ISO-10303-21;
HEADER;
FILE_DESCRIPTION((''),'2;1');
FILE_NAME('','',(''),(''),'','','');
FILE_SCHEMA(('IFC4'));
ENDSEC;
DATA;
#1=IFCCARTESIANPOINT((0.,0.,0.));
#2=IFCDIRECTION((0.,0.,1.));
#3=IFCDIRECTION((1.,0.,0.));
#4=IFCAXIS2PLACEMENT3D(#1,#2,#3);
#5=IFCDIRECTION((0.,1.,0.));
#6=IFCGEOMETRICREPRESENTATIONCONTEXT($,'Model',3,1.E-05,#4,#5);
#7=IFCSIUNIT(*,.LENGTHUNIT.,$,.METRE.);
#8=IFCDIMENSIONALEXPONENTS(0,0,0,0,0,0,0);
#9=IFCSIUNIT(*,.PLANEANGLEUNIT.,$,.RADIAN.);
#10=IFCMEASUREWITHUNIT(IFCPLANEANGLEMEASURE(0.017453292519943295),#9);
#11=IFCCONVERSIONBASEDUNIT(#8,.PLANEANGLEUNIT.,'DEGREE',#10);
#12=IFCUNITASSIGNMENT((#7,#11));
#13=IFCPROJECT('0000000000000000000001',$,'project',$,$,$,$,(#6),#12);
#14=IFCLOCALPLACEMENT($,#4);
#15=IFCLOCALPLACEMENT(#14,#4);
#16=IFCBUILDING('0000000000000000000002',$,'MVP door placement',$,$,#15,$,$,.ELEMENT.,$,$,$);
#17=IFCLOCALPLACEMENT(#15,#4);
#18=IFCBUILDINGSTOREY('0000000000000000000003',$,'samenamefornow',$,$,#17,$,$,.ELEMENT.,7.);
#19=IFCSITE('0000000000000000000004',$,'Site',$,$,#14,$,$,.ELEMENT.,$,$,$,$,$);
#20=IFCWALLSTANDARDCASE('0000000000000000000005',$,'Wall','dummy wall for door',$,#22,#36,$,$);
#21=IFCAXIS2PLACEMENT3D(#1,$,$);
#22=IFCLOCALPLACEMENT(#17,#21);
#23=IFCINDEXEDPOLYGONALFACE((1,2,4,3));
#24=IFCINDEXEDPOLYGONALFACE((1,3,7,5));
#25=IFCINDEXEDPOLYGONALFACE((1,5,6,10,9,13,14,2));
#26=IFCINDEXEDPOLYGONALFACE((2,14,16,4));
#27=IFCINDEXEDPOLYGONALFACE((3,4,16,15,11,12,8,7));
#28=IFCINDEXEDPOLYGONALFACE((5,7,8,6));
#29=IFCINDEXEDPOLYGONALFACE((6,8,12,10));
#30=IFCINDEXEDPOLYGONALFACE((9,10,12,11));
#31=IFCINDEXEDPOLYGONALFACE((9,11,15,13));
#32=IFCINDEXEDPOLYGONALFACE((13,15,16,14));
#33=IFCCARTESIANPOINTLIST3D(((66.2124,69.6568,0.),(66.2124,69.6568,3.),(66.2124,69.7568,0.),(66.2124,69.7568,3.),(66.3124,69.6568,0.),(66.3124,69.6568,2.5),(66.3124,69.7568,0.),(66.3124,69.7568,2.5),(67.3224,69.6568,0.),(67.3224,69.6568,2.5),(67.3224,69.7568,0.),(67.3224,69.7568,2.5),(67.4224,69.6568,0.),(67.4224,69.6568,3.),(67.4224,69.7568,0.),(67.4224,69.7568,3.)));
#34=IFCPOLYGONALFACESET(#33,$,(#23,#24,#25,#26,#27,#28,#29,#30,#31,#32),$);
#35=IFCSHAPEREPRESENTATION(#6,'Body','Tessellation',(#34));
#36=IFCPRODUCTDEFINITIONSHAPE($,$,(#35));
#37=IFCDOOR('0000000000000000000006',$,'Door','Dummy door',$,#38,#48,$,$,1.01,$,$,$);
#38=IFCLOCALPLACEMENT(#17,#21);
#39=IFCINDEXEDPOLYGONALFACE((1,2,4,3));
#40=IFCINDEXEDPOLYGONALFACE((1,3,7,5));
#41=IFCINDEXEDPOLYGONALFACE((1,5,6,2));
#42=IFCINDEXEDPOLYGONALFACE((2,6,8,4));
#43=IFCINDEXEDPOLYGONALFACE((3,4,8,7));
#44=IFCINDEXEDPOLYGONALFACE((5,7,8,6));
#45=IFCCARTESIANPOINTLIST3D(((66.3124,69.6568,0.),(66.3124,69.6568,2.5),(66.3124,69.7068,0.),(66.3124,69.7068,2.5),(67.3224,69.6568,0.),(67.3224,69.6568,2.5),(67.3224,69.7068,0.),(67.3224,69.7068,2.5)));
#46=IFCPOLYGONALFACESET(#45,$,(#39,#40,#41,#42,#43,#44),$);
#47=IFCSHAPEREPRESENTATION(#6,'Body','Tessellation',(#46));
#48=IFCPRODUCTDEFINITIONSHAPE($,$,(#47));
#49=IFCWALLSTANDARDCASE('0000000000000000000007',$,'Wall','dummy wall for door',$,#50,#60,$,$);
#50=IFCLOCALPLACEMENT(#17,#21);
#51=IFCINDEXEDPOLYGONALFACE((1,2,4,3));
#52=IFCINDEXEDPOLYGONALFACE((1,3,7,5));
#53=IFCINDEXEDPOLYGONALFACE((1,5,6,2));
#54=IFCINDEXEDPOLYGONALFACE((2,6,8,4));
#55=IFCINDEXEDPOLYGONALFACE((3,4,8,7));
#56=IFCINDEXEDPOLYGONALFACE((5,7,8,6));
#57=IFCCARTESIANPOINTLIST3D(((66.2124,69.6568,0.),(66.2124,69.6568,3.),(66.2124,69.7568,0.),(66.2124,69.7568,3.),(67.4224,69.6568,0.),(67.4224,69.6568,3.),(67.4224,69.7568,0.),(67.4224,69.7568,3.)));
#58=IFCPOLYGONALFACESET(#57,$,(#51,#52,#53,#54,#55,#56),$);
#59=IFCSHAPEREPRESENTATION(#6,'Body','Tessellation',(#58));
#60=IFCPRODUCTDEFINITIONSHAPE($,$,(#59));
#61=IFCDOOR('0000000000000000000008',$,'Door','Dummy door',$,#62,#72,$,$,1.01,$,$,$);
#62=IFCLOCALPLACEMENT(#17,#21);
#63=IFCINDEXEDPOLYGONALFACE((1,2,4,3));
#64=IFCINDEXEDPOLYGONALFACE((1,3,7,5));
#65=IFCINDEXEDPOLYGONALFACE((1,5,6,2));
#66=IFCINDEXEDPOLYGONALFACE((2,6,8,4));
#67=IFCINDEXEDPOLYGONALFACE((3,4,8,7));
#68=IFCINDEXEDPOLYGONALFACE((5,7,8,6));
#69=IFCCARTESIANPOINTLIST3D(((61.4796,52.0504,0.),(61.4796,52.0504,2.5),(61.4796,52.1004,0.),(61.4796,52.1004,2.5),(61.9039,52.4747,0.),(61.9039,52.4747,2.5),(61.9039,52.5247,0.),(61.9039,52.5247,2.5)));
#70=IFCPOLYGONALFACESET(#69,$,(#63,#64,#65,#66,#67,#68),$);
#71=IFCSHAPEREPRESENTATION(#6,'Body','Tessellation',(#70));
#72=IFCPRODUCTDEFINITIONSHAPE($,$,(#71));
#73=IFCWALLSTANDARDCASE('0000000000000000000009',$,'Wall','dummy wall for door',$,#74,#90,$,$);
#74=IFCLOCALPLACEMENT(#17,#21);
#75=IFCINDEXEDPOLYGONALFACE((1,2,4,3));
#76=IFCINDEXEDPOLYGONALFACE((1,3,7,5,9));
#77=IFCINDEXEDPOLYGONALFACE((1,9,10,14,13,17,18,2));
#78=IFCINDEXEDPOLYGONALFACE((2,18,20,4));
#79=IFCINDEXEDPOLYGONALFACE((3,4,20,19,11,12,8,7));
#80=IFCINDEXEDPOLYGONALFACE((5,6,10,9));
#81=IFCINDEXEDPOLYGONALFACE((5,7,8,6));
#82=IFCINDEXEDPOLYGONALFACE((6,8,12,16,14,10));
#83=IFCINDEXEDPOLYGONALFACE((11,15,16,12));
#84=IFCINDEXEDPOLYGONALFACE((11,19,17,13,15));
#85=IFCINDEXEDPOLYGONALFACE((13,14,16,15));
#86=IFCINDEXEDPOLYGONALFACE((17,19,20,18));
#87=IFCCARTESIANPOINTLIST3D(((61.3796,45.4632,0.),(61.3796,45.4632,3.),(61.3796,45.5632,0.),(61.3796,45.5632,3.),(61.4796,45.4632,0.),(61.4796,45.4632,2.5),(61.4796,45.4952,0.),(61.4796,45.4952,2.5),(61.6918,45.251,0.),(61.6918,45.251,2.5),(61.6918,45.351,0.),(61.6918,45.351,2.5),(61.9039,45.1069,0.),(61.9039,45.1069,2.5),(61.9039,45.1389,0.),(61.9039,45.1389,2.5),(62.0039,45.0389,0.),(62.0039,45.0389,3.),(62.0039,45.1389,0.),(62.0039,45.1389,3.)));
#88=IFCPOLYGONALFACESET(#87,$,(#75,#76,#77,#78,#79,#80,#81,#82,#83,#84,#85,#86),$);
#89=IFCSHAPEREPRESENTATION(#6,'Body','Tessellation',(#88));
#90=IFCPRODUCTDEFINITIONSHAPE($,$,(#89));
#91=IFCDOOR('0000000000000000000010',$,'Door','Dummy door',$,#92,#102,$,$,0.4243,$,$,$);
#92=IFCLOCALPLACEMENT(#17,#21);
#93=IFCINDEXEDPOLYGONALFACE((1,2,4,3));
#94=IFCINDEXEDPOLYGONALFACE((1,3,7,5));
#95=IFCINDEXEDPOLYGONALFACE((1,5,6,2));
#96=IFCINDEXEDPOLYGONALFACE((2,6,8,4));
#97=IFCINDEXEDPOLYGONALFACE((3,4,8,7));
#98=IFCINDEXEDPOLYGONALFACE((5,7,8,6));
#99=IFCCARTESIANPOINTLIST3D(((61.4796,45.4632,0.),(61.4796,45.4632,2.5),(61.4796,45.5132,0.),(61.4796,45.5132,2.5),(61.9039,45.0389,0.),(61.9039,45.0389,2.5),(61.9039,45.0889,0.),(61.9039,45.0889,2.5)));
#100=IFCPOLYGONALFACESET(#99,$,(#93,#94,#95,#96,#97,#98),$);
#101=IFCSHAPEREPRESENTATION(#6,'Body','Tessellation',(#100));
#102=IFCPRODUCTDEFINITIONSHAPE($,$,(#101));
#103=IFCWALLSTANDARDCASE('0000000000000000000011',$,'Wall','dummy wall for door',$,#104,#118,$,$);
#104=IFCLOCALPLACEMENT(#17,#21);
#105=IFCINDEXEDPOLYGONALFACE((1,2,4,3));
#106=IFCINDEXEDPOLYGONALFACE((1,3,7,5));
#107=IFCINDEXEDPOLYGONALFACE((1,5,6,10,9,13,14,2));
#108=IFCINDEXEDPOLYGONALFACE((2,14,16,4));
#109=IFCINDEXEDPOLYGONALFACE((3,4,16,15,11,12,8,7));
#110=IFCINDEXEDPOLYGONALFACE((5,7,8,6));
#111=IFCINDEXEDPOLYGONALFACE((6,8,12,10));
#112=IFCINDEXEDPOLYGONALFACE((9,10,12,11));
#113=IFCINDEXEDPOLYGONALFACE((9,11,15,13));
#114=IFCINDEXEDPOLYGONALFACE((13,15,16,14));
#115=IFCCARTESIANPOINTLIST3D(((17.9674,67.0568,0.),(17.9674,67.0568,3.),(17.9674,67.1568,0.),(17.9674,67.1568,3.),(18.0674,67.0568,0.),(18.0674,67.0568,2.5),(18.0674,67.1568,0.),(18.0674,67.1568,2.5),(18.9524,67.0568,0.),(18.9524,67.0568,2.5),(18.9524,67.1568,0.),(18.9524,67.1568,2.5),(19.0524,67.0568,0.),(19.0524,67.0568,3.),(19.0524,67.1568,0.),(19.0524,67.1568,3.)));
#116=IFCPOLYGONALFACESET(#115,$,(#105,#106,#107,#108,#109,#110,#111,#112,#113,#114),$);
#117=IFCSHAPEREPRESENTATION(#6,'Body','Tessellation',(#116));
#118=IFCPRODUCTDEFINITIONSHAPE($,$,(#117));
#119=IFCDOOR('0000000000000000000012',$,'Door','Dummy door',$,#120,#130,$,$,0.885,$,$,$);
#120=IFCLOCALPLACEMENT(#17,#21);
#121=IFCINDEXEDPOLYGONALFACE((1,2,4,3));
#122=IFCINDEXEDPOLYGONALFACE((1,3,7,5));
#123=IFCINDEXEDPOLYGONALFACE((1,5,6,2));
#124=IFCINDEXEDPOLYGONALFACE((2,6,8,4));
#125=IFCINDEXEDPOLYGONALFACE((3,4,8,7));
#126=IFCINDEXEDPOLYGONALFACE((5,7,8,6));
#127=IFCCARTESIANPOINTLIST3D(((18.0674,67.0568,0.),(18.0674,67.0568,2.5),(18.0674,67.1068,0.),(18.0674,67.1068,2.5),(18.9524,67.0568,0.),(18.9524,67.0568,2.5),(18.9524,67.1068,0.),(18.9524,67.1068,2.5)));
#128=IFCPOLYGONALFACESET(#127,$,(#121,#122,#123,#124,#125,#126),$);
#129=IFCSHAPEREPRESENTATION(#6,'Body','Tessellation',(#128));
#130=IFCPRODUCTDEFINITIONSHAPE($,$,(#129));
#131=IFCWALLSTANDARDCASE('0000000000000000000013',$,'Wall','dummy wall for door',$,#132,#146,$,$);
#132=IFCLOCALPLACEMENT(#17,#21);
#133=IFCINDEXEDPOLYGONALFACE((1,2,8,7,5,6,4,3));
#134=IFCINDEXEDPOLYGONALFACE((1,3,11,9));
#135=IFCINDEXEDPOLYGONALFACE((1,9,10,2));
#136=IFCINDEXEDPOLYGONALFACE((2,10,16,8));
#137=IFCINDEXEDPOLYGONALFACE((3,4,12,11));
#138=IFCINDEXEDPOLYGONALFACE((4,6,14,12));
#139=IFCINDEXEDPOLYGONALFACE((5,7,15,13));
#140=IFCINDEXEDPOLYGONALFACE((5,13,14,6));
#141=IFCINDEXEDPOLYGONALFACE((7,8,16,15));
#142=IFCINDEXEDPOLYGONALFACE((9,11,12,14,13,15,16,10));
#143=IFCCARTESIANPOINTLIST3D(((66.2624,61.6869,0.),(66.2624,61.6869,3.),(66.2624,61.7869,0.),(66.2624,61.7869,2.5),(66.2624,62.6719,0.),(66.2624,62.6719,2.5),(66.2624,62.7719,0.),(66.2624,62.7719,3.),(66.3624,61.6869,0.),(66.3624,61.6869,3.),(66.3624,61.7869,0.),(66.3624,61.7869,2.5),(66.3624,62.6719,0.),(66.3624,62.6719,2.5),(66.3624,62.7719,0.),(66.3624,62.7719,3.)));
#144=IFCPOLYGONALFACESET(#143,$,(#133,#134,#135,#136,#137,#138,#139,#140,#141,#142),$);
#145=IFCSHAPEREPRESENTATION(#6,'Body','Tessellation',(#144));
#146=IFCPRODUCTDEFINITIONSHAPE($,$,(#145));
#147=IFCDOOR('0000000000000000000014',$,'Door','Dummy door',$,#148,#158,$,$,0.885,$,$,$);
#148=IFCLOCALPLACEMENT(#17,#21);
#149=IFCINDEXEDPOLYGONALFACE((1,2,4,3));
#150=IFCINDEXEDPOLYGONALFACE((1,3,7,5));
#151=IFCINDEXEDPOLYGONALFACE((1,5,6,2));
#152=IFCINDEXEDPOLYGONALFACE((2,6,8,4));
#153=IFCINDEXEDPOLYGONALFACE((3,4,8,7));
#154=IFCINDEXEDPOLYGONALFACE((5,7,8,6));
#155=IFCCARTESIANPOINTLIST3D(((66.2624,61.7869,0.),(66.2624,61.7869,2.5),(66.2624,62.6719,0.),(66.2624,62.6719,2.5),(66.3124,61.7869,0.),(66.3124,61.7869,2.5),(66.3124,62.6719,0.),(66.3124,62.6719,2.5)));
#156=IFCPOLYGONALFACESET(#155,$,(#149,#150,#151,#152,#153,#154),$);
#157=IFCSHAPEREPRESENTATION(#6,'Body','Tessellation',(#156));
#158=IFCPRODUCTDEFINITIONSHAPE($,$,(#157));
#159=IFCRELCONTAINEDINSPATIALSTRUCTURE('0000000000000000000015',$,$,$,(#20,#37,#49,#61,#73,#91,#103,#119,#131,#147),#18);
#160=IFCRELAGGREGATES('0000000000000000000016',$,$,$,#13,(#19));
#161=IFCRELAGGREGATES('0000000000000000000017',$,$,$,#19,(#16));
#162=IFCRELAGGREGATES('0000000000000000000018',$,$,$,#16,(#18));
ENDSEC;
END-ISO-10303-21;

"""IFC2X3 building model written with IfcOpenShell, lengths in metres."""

from ifc_helpers import new_model, entity, si_unit, converted_unit, direction, origin_with_axes, place, context, project, spatial, polyline, outline, extrude, element, fill, save


model = new_model("IFC2X3")

# Units and contexts
model_context = context("Model", 3, precision=1e-05, world=origin_with_axes(), true_north=direction((0.0, 1.0, 0.0)))
ifc_project = project(units=[si_unit("LENGTHUNIT", "METRE"), converted_unit("PLANEANGLEUNIT", "DEGREE", entity("IfcPlaneAngleMeasure", 0.017453292519943295), si_unit("PLANEANGLEUNIT", "RADIAN"), dimensions=[0, 0, 0, 0, 0, 0, 0])], contexts=[model_context])

# Site, building, storey
site_placement = place(None, origin_with_axes())
site = spatial("IfcSite", under=ifc_project, at=site_placement, Name="Site", CompositionType="ELEMENT")
building_placement = place(site_placement, origin_with_axes())
building = spatial("IfcBuilding", under=site, at=building_placement, Name="MVP door placement", CompositionType="ELEMENT")
storey_placement = place(building_placement, origin_with_axes())
storey = spatial("IfcBuildingStorey", under=building, at=storey_placement, Name="samenamefornow", CompositionType="ELEMENT", Elevation=7.0)

# Walls, openings, doors
wall_1_placement = place(storey_placement, origin_with_axes())
wall_1 = element("IfcWallStandardCase", 1, at=wall_1_placement, inside=storey, Name="Wall", Description="dummy wall for door", context=model_context, shape_type="SweptSolid", body=[
    extrude(outline(polyline([(66.2124, 69.6568, 0.0), (67.4224, 69.6568, 0.0), (67.4224, 69.7568, 0.0), (66.2124, 69.7568, 0.0), (66.2124, 69.6568, 0.0)])), origin_with_axes(), (0.0, 0.0, 1.0), 3.0),
])
opening_1_placement = place(wall_1_placement, origin_with_axes())
opening_1 = element("IfcOpeningElement", 2, at=opening_1_placement, cuts=wall_1, context=model_context, shape_type="SweptSolid", body=[
    extrude(outline(polyline([(66.3124, 69.6568, 0.0), (67.3224, 69.6568, 0.0), (67.3224, 69.7568, 0.0), (66.3124, 69.7568, 0.0), (66.3124, 69.6568, 0.0)])), origin_with_axes(), (0.0, 0.0, 1.0), 2.5),
])
door_1_placement = place(opening_1_placement, origin_with_axes())
door_1 = element("IfcDoor", 3, at=door_1_placement, inside=storey, Name="Door", Description="Dummy door", OverallWidth=1.01, context=model_context, shape_type="SweptSolid", body=[
    extrude(outline(polyline([(66.3124, 69.6568, 0.0), (67.3224, 69.6568, 0.0), (67.3224, 69.7068, 0.0), (66.3124, 69.7068, 0.0), (66.3124, 69.6568, 0.0)])), origin_with_axes(), (0.0, 0.0, 1.0), 2.5),
])
fill(opening_1, door_1)
wall_2_placement = place(storey_placement, origin_with_axes())
wall_2 = element("IfcWallStandardCase", 4, at=wall_2_placement, inside=storey, Name="Wall", Description="dummy wall for door", context=model_context, shape_type="SweptSolid", body=[
    extrude(outline(polyline([(66.2124, 69.6568, 0.0), (67.4224, 69.6568, 0.0), (67.4224, 69.7568, 0.0), (66.2124, 69.7568, 0.0), (66.2124, 69.6568, 0.0)])), origin_with_axes(), (0.0, 0.0, 1.0), 3.0),
])
opening_2_placement = place(wall_2_placement, origin_with_axes())
opening_2 = element("IfcOpeningElement", 5, at=opening_2_placement, cuts=wall_2, context=model_context, shape_type="SweptSolid", body=[
    extrude(outline(polyline([(61.4796, 52.0504, 0.0), (61.9039, 52.4747, 0.0), (61.9039, 52.5747, 0.0), (61.4796, 52.1504, 0.0), (61.4796, 52.0504, 0.0)])), origin_with_axes(), (0.0, 0.0, 1.0), 2.5),
])
door_2_placement = place(opening_2_placement, origin_with_axes())
door_2 = element("IfcDoor", 6, at=door_2_placement, inside=storey, Name="Door", Description="Dummy door", OverallWidth=1.01, context=model_context, shape_type="SweptSolid", body=[
    extrude(outline(polyline([(61.4796, 52.0504, 0.0), (61.9039, 52.4747, 0.0), (61.9039, 52.5247, 0.0), (61.4796, 52.1004, 0.0), (61.4796, 52.0504, 0.0)])), origin_with_axes(), (0.0, 0.0, 1.0), 2.5),
])
fill(opening_2, door_2)
wall_3_placement = place(storey_placement, origin_with_axes())
wall_3 = element("IfcWallStandardCase", 7, at=wall_3_placement, inside=storey, Name="Wall", Description="dummy wall for door", context=model_context, shape_type="SweptSolid", body=[
    extrude(outline(polyline([(61.3796, 45.4632, 0.0), (62.0039, 45.0389, 0.0), (62.0039, 45.1389, 0.0), (61.3796, 45.5632, 0.0), (61.3796, 45.4632, 0.0)])), origin_with_axes(), (0.0, 0.0, 1.0), 3.0),
])
opening_3_placement = place(wall_3_placement, origin_with_axes())
opening_3 = element("IfcOpeningElement", 8, at=opening_3_placement, cuts=wall_3, context=model_context, shape_type="SweptSolid", body=[
    extrude(outline(polyline([(61.4796, 45.4632, 0.0), (61.9039, 45.0389, 0.0), (61.9039, 45.1389, 0.0), (61.4796, 45.5632, 0.0), (61.4796, 45.4632, 0.0)])), origin_with_axes(), (0.0, 0.0, 1.0), 2.5),
])
door_3_placement = place(opening_3_placement, origin_with_axes())
door_3 = element("IfcDoor", 9, at=door_3_placement, inside=storey, Name="Door", Description="Dummy door", OverallWidth=0.4243, context=model_context, shape_type="SweptSolid", body=[
    extrude(outline(polyline([(61.4796, 45.4632, 0.0), (61.9039, 45.0389, 0.0), (61.9039, 45.0889, 0.0), (61.4796, 45.5132, 0.0), (61.4796, 45.4632, 0.0)])), origin_with_axes(), (0.0, 0.0, 1.0), 2.5),
])
fill(opening_3, door_3)
wall_4_placement = place(storey_placement, origin_with_axes())
wall_4 = element("IfcWallStandardCase", 10, at=wall_4_placement, inside=storey, Name="Wall", Description="dummy wall for door", context=model_context, shape_type="SweptSolid", body=[
    extrude(outline(polyline([(17.9674, 67.0568, 0.0), (19.0524, 67.0568, 0.0), (19.0524, 67.1568, 0.0), (17.9674, 67.1568, 0.0), (17.9674, 67.0568, 0.0)])), origin_with_axes(), (0.0, 0.0, 1.0), 3.0),
])
opening_4_placement = place(wall_4_placement, origin_with_axes())
opening_4 = element("IfcOpeningElement", 11, at=opening_4_placement, cuts=wall_4, context=model_context, shape_type="SweptSolid", body=[
    extrude(outline(polyline([(18.0674, 67.0568, 0.0), (18.9524, 67.0568, 0.0), (18.9524, 67.1568, 0.0), (18.0674, 67.1568, 0.0), (18.0674, 67.0568, 0.0)])), origin_with_axes(), (0.0, 0.0, 1.0), 2.5),
])
door_4_placement = place(opening_4_placement, origin_with_axes())
door_4 = element("IfcDoor", 12, at=door_4_placement, inside=storey, Name="Door", Description="Dummy door", OverallWidth=0.885, context=model_context, shape_type="SweptSolid", body=[
    extrude(outline(polyline([(18.0674, 67.0568, 0.0), (18.9524, 67.0568, 0.0), (18.9524, 67.1068, 0.0), (18.0674, 67.1068, 0.0), (18.0674, 67.0568, 0.0)])), origin_with_axes(), (0.0, 0.0, 1.0), 2.5),
])
fill(opening_4, door_4)
wall_5_placement = place(storey_placement, origin_with_axes())
wall_5 = element("IfcWallStandardCase", 13, at=wall_5_placement, inside=storey, Name="Wall", Description="dummy wall for door", context=model_context, shape_type="SweptSolid", body=[
    extrude(outline(polyline([(66.2624, 62.7719, 0.0), (66.2624, 61.6869, 0.0), (66.3624, 61.6869, 0.0), (66.3624, 62.7719, 0.0), (66.2624, 62.7719, 0.0)])), origin_with_axes(), (0.0, 0.0, 1.0), 3.0),
])
opening_5_placement = place(wall_5_placement, origin_with_axes())
opening_5 = element("IfcOpeningElement", 14, at=opening_5_placement, cuts=wall_5, context=model_context, shape_type="SweptSolid", body=[
    extrude(outline(polyline([(66.2624, 62.6719, 0.0), (66.2624, 61.7869, 0.0), (66.3624, 61.7869, 0.0), (66.3624, 62.6719, 0.0), (66.2624, 62.6719, 0.0)])), origin_with_axes(), (0.0, 0.0, 1.0), 2.5),
])
door_5_placement = place(opening_5_placement, origin_with_axes())
door_5 = element("IfcDoor", 15, at=door_5_placement, inside=storey, Name="Door", Description="Dummy door", OverallWidth=0.885, context=model_context, shape_type="SweptSolid", body=[
    extrude(outline(polyline([(66.2624, 62.6719, 0.0), (66.2624, 61.7869, 0.0), (66.3124, 61.7869, 0.0), (66.3124, 62.6719, 0.0), (66.2624, 62.6719, 0.0)])), origin_with_axes(), (0.0, 0.0, 1.0), 2.5),
])
fill(opening_5, door_5)

save(model, "model.ifc")
